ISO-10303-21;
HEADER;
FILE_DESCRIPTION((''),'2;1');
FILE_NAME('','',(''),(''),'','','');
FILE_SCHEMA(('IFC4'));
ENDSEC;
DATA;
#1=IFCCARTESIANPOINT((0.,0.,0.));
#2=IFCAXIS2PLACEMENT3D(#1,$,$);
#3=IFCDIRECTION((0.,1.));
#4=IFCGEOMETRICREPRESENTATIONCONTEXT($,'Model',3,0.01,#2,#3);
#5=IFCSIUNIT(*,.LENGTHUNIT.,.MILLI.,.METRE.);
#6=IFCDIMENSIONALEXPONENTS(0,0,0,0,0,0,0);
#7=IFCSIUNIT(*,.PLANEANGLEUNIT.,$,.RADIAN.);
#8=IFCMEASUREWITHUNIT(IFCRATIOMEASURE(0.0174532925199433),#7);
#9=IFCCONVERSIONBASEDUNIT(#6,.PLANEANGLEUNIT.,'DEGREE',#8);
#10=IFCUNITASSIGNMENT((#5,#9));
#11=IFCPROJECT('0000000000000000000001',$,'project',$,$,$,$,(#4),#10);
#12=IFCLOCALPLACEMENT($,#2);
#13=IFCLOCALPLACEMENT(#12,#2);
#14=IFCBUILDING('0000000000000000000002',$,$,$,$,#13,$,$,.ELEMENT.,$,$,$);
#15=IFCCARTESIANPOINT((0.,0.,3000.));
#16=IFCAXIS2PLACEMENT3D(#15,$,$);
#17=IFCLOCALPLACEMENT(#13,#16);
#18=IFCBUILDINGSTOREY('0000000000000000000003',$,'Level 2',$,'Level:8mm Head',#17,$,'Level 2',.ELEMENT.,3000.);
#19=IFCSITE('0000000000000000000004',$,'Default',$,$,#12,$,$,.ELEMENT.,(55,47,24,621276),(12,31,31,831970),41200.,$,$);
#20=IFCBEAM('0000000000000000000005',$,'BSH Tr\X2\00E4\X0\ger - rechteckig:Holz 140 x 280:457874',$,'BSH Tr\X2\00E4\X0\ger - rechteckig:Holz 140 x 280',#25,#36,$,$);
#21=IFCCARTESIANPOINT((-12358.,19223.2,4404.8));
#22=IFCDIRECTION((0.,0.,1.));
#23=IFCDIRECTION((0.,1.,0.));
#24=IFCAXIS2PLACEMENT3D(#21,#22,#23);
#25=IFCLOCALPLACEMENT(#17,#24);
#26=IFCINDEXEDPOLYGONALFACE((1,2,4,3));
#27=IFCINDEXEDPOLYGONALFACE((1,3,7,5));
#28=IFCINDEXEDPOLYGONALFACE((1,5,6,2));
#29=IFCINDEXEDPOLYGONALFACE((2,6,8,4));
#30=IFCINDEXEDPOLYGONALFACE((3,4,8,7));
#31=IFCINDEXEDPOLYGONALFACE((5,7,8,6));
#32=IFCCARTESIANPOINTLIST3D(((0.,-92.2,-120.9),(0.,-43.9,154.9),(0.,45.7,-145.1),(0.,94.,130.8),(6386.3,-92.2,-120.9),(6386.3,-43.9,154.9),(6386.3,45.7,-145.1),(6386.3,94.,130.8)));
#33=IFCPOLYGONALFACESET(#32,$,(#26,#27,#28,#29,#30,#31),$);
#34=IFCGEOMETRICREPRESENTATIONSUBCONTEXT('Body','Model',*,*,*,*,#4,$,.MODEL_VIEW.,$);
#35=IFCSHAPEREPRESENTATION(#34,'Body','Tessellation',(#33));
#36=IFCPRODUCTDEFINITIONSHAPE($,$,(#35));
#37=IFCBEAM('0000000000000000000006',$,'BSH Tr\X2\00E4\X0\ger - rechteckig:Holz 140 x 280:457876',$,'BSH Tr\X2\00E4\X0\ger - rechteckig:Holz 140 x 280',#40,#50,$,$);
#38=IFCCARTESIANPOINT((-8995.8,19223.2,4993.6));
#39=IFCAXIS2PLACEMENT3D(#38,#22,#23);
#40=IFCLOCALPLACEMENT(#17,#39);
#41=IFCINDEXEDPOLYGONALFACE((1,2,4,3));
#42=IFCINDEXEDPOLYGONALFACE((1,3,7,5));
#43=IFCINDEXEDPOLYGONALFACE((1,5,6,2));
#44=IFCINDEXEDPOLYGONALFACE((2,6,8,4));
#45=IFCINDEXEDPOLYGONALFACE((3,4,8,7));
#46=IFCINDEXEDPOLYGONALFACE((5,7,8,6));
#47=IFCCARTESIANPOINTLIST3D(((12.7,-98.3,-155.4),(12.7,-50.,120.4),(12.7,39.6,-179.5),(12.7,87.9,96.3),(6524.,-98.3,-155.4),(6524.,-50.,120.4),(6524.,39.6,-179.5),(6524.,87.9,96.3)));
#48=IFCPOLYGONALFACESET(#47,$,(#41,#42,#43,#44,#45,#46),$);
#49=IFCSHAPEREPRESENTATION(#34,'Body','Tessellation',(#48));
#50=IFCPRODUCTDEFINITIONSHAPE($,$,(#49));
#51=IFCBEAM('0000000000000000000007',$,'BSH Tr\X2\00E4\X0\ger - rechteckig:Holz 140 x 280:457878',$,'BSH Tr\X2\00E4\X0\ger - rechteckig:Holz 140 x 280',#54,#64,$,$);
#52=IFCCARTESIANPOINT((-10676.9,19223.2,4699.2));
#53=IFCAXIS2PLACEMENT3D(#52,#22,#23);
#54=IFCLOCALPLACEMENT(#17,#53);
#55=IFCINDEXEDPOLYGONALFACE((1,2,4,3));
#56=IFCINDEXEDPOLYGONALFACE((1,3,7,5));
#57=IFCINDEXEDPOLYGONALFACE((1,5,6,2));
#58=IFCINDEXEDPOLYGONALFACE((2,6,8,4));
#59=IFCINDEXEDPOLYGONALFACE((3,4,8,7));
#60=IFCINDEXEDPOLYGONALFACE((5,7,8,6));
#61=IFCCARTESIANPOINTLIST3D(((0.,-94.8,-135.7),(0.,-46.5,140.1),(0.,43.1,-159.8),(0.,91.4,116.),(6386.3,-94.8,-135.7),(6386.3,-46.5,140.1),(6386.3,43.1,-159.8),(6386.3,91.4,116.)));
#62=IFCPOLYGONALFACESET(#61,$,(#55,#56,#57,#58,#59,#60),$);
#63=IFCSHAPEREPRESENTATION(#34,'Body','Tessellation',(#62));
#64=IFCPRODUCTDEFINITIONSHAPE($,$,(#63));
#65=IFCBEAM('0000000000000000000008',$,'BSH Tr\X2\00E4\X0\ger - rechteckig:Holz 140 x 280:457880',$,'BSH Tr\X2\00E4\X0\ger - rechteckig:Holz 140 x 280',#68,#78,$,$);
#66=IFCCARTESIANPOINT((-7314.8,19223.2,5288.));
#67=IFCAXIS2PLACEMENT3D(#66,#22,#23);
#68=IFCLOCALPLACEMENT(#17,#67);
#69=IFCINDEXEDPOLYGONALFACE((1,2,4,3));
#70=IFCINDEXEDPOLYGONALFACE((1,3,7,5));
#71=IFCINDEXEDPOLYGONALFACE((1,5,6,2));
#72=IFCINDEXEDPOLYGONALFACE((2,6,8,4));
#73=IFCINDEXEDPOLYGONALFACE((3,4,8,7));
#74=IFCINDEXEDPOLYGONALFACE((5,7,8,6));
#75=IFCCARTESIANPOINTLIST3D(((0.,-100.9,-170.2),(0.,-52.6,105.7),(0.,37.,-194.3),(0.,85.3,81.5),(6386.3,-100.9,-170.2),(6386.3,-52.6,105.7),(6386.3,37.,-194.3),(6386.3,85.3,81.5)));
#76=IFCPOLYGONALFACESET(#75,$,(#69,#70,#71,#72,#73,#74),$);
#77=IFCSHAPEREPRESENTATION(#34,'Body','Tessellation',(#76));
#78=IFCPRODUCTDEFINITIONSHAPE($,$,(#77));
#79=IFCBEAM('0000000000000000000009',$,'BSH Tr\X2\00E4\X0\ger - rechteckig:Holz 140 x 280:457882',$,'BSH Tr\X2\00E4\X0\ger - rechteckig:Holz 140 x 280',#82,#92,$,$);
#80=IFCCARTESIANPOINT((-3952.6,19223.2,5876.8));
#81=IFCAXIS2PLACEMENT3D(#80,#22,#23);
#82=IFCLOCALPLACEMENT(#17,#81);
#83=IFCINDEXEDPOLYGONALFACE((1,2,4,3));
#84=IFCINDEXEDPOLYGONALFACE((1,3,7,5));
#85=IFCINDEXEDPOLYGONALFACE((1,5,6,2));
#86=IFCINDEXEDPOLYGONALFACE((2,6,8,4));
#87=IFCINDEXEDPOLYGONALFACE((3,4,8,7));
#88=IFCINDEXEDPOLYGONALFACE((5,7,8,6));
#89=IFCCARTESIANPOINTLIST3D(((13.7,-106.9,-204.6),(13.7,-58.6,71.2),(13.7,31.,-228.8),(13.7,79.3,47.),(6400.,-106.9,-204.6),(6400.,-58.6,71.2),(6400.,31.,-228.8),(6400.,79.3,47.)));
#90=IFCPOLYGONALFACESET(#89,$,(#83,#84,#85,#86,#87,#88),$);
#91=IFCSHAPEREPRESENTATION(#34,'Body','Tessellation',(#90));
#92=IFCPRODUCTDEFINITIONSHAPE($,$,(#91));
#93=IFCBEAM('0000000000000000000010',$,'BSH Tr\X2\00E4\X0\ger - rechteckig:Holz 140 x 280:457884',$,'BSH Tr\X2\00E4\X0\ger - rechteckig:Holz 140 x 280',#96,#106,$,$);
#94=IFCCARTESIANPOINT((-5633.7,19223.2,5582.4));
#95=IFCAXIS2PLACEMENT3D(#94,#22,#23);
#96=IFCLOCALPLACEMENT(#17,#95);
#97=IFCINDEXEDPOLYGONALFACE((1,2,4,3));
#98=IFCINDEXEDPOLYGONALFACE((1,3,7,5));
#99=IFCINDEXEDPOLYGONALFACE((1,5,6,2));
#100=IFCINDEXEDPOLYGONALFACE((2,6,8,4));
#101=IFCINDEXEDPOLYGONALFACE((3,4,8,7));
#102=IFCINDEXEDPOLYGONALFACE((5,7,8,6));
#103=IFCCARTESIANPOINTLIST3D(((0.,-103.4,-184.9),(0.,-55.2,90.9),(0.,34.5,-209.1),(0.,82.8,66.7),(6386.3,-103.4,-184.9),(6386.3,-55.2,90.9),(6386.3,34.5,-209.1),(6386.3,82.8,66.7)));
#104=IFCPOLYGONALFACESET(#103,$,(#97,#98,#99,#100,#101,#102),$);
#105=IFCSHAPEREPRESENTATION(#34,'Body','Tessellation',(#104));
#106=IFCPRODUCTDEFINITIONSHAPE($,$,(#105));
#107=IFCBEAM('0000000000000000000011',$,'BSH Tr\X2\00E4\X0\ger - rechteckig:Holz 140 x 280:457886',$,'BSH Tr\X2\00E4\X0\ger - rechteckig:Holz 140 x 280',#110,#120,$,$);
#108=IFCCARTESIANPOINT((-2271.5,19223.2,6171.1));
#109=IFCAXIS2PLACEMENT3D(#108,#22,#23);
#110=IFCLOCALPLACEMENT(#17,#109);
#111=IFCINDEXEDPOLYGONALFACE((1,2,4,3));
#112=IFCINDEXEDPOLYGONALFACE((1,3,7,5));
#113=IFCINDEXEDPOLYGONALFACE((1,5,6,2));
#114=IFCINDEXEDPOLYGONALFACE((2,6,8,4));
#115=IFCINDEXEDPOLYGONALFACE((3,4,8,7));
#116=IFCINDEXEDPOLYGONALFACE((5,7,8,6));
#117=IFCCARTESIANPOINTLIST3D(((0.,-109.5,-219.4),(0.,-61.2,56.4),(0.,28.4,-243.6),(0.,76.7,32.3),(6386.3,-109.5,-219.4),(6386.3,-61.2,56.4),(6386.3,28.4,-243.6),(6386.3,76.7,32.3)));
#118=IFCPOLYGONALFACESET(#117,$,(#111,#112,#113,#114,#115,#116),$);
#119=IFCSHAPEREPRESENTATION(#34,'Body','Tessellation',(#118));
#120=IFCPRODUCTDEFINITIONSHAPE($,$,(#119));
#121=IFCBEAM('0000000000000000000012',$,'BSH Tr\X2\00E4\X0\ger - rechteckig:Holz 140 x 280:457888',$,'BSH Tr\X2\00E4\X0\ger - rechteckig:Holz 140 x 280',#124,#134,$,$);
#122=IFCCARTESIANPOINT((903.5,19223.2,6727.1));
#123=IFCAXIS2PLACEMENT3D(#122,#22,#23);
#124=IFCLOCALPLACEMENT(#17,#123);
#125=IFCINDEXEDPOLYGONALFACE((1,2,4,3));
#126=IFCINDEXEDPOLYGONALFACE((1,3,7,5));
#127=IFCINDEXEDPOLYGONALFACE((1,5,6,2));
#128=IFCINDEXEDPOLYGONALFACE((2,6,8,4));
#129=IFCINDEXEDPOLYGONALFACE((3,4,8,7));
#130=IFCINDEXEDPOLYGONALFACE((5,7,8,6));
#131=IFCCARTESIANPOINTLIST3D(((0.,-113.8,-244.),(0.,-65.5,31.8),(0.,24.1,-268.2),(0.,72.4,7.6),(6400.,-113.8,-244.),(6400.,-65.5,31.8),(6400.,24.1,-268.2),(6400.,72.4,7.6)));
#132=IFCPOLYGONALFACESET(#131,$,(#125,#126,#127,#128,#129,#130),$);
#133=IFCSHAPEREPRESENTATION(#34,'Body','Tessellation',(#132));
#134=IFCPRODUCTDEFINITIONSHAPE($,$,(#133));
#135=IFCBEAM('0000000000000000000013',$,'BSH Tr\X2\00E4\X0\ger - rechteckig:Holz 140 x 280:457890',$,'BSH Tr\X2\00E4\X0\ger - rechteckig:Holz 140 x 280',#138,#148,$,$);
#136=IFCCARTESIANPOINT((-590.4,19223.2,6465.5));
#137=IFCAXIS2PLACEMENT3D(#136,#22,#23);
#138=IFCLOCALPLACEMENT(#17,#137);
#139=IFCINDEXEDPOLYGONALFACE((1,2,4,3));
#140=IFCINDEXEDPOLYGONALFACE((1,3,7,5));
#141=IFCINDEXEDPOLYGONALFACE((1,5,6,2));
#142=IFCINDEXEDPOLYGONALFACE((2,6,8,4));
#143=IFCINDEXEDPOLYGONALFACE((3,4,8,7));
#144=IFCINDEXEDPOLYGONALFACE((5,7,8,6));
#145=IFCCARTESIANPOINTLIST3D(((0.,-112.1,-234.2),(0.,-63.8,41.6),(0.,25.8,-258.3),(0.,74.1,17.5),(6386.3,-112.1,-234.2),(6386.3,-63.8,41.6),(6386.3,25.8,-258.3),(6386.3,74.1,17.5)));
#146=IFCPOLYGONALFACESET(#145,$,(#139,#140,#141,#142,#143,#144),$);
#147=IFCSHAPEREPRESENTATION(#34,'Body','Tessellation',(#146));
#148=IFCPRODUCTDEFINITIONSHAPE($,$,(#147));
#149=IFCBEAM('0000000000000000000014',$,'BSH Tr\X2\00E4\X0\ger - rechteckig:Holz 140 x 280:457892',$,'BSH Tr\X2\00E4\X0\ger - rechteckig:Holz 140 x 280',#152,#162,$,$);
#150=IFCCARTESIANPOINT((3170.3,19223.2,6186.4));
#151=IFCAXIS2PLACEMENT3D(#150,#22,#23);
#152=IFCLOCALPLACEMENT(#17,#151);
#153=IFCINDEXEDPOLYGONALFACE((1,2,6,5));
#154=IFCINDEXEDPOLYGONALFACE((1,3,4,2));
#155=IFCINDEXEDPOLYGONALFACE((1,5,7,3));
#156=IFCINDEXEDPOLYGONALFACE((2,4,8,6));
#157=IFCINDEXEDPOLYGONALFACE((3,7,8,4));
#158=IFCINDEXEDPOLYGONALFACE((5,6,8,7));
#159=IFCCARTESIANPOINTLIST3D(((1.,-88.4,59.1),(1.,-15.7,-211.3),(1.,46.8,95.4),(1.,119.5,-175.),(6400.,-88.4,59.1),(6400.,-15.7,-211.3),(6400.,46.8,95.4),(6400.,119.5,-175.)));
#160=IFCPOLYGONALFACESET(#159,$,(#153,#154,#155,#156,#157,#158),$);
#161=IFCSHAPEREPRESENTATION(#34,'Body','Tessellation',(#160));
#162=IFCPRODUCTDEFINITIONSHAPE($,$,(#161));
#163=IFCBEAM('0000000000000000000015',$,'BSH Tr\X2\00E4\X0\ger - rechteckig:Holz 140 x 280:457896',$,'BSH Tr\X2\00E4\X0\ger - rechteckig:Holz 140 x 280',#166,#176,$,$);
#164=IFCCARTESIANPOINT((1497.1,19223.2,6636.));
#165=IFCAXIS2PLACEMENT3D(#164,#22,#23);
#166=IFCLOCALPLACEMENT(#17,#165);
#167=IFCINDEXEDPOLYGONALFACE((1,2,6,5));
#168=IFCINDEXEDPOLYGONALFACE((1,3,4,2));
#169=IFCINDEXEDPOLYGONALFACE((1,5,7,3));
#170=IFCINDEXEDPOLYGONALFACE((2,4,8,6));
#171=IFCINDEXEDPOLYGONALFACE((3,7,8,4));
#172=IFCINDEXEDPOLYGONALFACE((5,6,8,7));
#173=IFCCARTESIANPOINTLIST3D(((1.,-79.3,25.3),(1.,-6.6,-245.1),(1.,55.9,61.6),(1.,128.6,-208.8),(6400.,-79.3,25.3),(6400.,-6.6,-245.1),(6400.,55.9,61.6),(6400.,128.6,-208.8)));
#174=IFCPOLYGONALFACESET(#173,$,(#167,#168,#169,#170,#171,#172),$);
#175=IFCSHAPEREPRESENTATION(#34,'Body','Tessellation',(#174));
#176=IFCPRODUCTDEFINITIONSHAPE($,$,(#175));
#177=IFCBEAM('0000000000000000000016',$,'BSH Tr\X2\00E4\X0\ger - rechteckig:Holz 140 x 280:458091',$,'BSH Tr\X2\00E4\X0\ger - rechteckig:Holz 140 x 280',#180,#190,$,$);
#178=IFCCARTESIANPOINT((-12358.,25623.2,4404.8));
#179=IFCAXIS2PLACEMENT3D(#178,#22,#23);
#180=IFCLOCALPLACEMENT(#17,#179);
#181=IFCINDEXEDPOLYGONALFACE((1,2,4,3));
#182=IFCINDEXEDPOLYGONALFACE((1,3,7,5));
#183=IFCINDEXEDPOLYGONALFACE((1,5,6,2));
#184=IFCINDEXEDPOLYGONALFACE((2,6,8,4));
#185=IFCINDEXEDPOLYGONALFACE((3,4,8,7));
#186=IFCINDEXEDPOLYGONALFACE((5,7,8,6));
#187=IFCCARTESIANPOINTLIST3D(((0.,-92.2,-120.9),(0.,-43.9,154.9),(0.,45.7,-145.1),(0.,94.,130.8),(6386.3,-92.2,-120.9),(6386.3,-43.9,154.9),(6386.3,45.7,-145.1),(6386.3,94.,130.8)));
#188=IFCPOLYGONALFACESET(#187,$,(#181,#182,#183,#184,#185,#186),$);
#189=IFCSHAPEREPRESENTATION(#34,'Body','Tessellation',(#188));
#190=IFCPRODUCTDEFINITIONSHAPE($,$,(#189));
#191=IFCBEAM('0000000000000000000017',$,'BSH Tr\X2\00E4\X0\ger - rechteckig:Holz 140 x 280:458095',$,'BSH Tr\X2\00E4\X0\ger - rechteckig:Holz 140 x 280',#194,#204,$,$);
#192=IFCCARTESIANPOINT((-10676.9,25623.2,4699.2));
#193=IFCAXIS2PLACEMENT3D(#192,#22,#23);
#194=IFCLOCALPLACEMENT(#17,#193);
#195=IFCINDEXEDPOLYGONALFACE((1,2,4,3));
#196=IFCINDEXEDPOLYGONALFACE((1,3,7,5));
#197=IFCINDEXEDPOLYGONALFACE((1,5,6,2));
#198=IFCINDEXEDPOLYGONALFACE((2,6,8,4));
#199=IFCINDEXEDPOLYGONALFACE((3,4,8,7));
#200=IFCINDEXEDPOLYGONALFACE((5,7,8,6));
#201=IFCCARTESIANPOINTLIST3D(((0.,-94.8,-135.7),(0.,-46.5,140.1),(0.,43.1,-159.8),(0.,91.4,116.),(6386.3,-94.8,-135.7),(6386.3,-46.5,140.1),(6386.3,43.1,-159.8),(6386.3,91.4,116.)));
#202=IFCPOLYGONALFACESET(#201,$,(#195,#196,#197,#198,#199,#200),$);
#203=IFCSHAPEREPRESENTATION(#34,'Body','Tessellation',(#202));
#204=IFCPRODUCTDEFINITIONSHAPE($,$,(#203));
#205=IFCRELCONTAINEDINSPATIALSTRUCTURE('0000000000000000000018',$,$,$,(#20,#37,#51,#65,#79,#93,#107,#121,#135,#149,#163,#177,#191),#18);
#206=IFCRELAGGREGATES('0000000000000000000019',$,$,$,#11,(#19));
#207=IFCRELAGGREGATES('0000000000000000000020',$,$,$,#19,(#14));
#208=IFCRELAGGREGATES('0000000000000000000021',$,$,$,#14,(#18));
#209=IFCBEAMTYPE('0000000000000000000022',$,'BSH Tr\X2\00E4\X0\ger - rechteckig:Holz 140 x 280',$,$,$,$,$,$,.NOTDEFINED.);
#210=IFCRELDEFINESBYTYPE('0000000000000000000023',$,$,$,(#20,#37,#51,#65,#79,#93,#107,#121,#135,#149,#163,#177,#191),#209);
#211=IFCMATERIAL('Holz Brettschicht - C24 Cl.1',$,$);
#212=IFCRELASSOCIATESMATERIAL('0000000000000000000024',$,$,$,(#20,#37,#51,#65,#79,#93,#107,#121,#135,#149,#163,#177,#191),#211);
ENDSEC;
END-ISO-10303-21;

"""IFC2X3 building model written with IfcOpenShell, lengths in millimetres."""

from ifc_helpers import new_model, entity, si_unit, converted_unit, direction, frame, frame_2d, origin, origin_2d_with_axis, place, context, subcontext, project, spatial, rectangle, extrude, material, type_object, element, save


model = new_model("IFC2X3")

# Units and contexts
model_context = context("Model", 3, precision=0.01, world=origin(), true_north=direction((0.0, 1.0)))
body_context = subcontext(model_context, "Body", "Model", "MODEL_VIEW")
ifc_project = project(units=[si_unit("LENGTHUNIT", "METRE", prefix="MILLI"), converted_unit("PLANEANGLEUNIT", "DEGREE", entity("IfcRatioMeasure", 0.0174532925199433), si_unit("PLANEANGLEUNIT", "RADIAN"), dimensions=[0, 0, 0, 0, 0, 0, 0])], contexts=[model_context])

# Site, building, storey
site_placement = place(None, origin())
site = spatial("IfcSite", under=ifc_project, at=site_placement, Name="Default", CompositionType="ELEMENT", RefLatitude=(55, 47, 24, 621276), RefLongitude=(12, 31, 31, 831970), RefElevation=41200.0)
building_placement = place(site_placement, origin())
building = spatial("IfcBuilding", under=site, at=building_placement, CompositionType="ELEMENT")
storey_placement = place(building_placement, frame((0.0, 0.0, 3000.0)))
storey = spatial("IfcBuildingStorey", under=building, at=storey_placement, Name="Level 2", ObjectType="Level:8mm Head", LongName="Level 2", CompositionType="ELEMENT", Elevation=3000.0)

# Beams
ifc_material = material(Name="Holz Brettschicht - C24 Cl.1")
beam_type_1 = type_object("IfcBeamType", Name="BSH Träger - rechteckig:Holz 140 x 280", PredefinedType="NOTDEFINED")
beam_1_placement = place(storey_placement, frame((-12358.0, 19223.2, 4404.8), z_axis=(0.0, 0.0, 1.0), x_axis=(0.0, 1.0, 0.0)))
element("IfcBeam", 1, at=beam_1_placement, inside=storey, type_object=beam_type_1, material=ifc_material, Name="BSH Träger - rechteckig:Holz 140 x 280:457874", ObjectType="BSH Träger - rechteckig:Holz 140 x 280", context=body_context, shape_type="SweptSolid", body=[
    extrude(rectangle(XDim=280.0, YDim=140.0, at=origin_2d_with_axis()), frame((0.0, 0.9, 4.9), z_axis=(1.0, 0.0, 0.0), x_axis=(0.0, 0.172491, 0.985011)), (0.0, 0.0, 1.0), 6386.3),
])
beam_2_placement = place(storey_placement, frame((-8995.8, 19223.2, 4993.6), z_axis=(0.0, 0.0, 1.0), x_axis=(0.0, 1.0, 0.0)))
element("IfcBeam", 2, at=beam_2_placement, inside=storey, type_object=beam_type_1, material=ifc_material, Name="BSH Träger - rechteckig:Holz 140 x 280:457876", ObjectType="BSH Träger - rechteckig:Holz 140 x 280", context=body_context, shape_type="SweptSolid", body=[
    extrude(rectangle(XDim=280.0, YDim=140.0, at=origin_2d_with_axis()), frame((12.7, -5.2, -29.6), z_axis=(1.0, 0.0, 0.0), x_axis=(0.0, 0.172491, 0.985011)), (0.0, 0.0, 1.0), 6511.3),
])
beam_3_placement = place(storey_placement, frame((-10676.9, 19223.2, 4699.2), z_axis=(0.0, 0.0, 1.0), x_axis=(0.0, 1.0, 0.0)))
element("IfcBeam", 3, at=beam_3_placement, inside=storey, type_object=beam_type_1, material=ifc_material, Name="BSH Träger - rechteckig:Holz 140 x 280:457878", ObjectType="BSH Träger - rechteckig:Holz 140 x 280", context=body_context, shape_type="SweptSolid", body=[
    extrude(rectangle(XDim=280.0, YDim=140.0, at=origin_2d_with_axis()), frame((0.0, -1.7, -9.9), z_axis=(1.0, 0.0, 0.0), x_axis=(0.0, 0.172491, 0.985011)), (0.0, 0.0, 1.0), 6386.3),
])
beam_4_placement = place(storey_placement, frame((-7314.8, 19223.2, 5288.0), z_axis=(0.0, 0.0, 1.0), x_axis=(0.0, 1.0, 0.0)))
element("IfcBeam", 4, at=beam_4_placement, inside=storey, type_object=beam_type_1, material=ifc_material, Name="BSH Träger - rechteckig:Holz 140 x 280:457880", ObjectType="BSH Träger - rechteckig:Holz 140 x 280", context=body_context, shape_type="SweptSolid", body=[
    extrude(rectangle(XDim=280.0, YDim=140.0, at=origin_2d_with_axis()), frame((0.0, -7.8, -44.3), z_axis=(1.0, 0.0, 0.0), x_axis=(0.0, 0.172491, 0.985011)), (0.0, 0.0, 1.0), 6386.3),
])
beam_5_placement = place(storey_placement, frame((-3952.6, 19223.2, 5876.8), z_axis=(0.0, 0.0, 1.0), x_axis=(0.0, 1.0, 0.0)))
element("IfcBeam", 5, at=beam_5_placement, inside=storey, type_object=beam_type_1, material=ifc_material, Name="BSH Träger - rechteckig:Holz 140 x 280:457882", ObjectType="BSH Träger - rechteckig:Holz 140 x 280", context=body_context, shape_type="SweptSolid", body=[
    extrude(rectangle(XDim=280.0, YDim=140.0, at=origin_2d_with_axis()), frame((13.7, -13.8, -78.8), z_axis=(1.0, 0.0, 0.0), x_axis=(0.0, 0.172491, 0.985011)), (0.0, 0.0, 1.0), 6386.3),
])
beam_6_placement = place(storey_placement, frame((-5633.7, 19223.2, 5582.4), z_axis=(0.0, 0.0, 1.0), x_axis=(0.0, 1.0, 0.0)))
element("IfcBeam", 6, at=beam_6_placement, inside=storey, type_object=beam_type_1, material=ifc_material, Name="BSH Träger - rechteckig:Holz 140 x 280:457884", ObjectType="BSH Träger - rechteckig:Holz 140 x 280", context=body_context, shape_type="SweptSolid", body=[
    extrude(rectangle(XDim=280.0, YDim=140.0, at=origin_2d_with_axis()), frame((0.0, -10.3, -59.1), z_axis=(1.0, 0.0, 0.0), x_axis=(0.0, 0.172491, 0.985011)), (0.0, 0.0, 1.0), 6386.3),
])
beam_7_placement = place(storey_placement, frame((-2271.5, 19223.2, 6171.1), z_axis=(0.0, 0.0, 1.0), x_axis=(0.0, 1.0, 0.0)))
element("IfcBeam", 7, at=beam_7_placement, inside=storey, type_object=beam_type_1, material=ifc_material, Name="BSH Träger - rechteckig:Holz 140 x 280:457886", ObjectType="BSH Träger - rechteckig:Holz 140 x 280", context=body_context, shape_type="SweptSolid", body=[
    extrude(rectangle(XDim=280.0, YDim=140.0, at=frame_2d((0.0, 0.0), x_axis=(1.0, 0.0))), frame((0.0, -16.4, -93.6), z_axis=(1.0, 0.0, 0.0), x_axis=(0.0, 0.172491, 0.985011)), (0.0, 0.0, 1.0), 6386.3),
])
beam_8_placement = place(storey_placement, frame((903.5, 19223.2, 6727.1), z_axis=(0.0, 0.0, 1.0), x_axis=(0.0, 1.0, 0.0)))
element("IfcBeam", 8, at=beam_8_placement, inside=storey, type_object=beam_type_1, material=ifc_material, Name="BSH Träger - rechteckig:Holz 140 x 280:457888", ObjectType="BSH Träger - rechteckig:Holz 140 x 280", context=body_context, shape_type="SweptSolid", body=[
    extrude(rectangle(XDim=280.0, YDim=140.0, at=frame_2d((0.0, 0.0), x_axis=(1.0, 0.0))), frame((0.0, -20.7, -118.2), z_axis=(1.0, 0.0, 0.0), x_axis=(0.0, 0.172491, 0.985011)), (0.0, 0.0, 1.0), 6400.0),
])
beam_9_placement = place(storey_placement, frame((-590.4, 19223.2, 6465.5), z_axis=(0.0, 0.0, 1.0), x_axis=(0.0, 1.0, 0.0)))
element("IfcBeam", 9, at=beam_9_placement, inside=storey, type_object=beam_type_1, material=ifc_material, Name="BSH Träger - rechteckig:Holz 140 x 280:457890", ObjectType="BSH Träger - rechteckig:Holz 140 x 280", context=body_context, shape_type="SweptSolid", body=[
    extrude(rectangle(XDim=280.0, YDim=140.0, at=frame_2d((0.0, 0.0), x_axis=(1.0, 0.0))), frame((0.0, -19.0, -108.4), z_axis=(1.0, 0.0, 0.0), x_axis=(0.0, 0.172491, 0.985011)), (0.0, 0.0, 1.0), 6386.3),
])
beam_10_placement = place(storey_placement, frame((3170.3, 19223.2, 6186.4), z_axis=(0.0, 0.0, 1.0), x_axis=(0.0, 1.0, 0.0)))
element("IfcBeam", 10, at=beam_10_placement, inside=storey, type_object=beam_type_1, material=ifc_material, Name="BSH Träger - rechteckig:Holz 140 x 280:457892", ObjectType="BSH Träger - rechteckig:Holz 140 x 280", context=body_context, shape_type="SweptSolid", body=[
    extrude(rectangle(XDim=280.0, YDim=140.0, at=frame_2d((0.0, 0.0), x_axis=(1.0, 0.0))), frame((1.0, 15.6, -57.9), z_axis=(1.0, 0.0, 0.0), x_axis=(0.0, -0.259528, 0.965735)), (0.0, 0.0, 1.0), 6399.0),
])
beam_11_placement = place(storey_placement, frame((1497.1, 19223.2, 6636.0), z_axis=(0.0, 0.0, 1.0), x_axis=(0.0, 1.0, 0.0)))
element("IfcBeam", 11, at=beam_11_placement, inside=storey, type_object=beam_type_1, material=ifc_material, Name="BSH Träger - rechteckig:Holz 140 x 280:457896", ObjectType="BSH Träger - rechteckig:Holz 140 x 280", context=body_context, shape_type="SweptSolid", body=[
    extrude(rectangle(XDim=280.0, YDim=140.0, at=frame_2d((0.0, 0.0), x_axis=(1.0, 0.0))), frame((1.0, 24.7, -91.7), z_axis=(1.0, 0.0, 0.0), x_axis=(0.0, -0.259528, 0.965735)), (0.0, 0.0, 1.0), 6399.0),
])
beam_12_placement = place(storey_placement, frame((-12358.0, 25623.2, 4404.8), z_axis=(0.0, 0.0, 1.0), x_axis=(0.0, 1.0, 0.0)))
element("IfcBeam", 12, at=beam_12_placement, inside=storey, type_object=beam_type_1, material=ifc_material, Name="BSH Träger - rechteckig:Holz 140 x 280:458091", ObjectType="BSH Träger - rechteckig:Holz 140 x 280", context=body_context, shape_type="SweptSolid", body=[
    extrude(rectangle(XDim=280.0, YDim=140.0, at=origin_2d_with_axis()), frame((0.0, 0.9, 4.9), z_axis=(1.0, 0.0, 0.0), x_axis=(0.0, 0.172491, 0.985011)), (0.0, 0.0, 1.0), 6386.3),
])
beam_13_placement = place(storey_placement, frame((-10676.9, 25623.2, 4699.2), z_axis=(0.0, 0.0, 1.0), x_axis=(0.0, 1.0, 0.0)))
element("IfcBeam", 13, at=beam_13_placement, inside=storey, type_object=beam_type_1, material=ifc_material, Name="BSH Träger - rechteckig:Holz 140 x 280:458095", ObjectType="BSH Träger - rechteckig:Holz 140 x 280", context=body_context, shape_type="SweptSolid", body=[
    extrude(rectangle(XDim=280.0, YDim=140.0, at=origin_2d_with_axis()), frame((0.0, -1.7, -9.9), z_axis=(1.0, 0.0, 0.0), x_axis=(0.0, 0.172491, 0.985011)), (0.0, 0.0, 1.0), 6386.3),
])

save(model, "model.ifc")
